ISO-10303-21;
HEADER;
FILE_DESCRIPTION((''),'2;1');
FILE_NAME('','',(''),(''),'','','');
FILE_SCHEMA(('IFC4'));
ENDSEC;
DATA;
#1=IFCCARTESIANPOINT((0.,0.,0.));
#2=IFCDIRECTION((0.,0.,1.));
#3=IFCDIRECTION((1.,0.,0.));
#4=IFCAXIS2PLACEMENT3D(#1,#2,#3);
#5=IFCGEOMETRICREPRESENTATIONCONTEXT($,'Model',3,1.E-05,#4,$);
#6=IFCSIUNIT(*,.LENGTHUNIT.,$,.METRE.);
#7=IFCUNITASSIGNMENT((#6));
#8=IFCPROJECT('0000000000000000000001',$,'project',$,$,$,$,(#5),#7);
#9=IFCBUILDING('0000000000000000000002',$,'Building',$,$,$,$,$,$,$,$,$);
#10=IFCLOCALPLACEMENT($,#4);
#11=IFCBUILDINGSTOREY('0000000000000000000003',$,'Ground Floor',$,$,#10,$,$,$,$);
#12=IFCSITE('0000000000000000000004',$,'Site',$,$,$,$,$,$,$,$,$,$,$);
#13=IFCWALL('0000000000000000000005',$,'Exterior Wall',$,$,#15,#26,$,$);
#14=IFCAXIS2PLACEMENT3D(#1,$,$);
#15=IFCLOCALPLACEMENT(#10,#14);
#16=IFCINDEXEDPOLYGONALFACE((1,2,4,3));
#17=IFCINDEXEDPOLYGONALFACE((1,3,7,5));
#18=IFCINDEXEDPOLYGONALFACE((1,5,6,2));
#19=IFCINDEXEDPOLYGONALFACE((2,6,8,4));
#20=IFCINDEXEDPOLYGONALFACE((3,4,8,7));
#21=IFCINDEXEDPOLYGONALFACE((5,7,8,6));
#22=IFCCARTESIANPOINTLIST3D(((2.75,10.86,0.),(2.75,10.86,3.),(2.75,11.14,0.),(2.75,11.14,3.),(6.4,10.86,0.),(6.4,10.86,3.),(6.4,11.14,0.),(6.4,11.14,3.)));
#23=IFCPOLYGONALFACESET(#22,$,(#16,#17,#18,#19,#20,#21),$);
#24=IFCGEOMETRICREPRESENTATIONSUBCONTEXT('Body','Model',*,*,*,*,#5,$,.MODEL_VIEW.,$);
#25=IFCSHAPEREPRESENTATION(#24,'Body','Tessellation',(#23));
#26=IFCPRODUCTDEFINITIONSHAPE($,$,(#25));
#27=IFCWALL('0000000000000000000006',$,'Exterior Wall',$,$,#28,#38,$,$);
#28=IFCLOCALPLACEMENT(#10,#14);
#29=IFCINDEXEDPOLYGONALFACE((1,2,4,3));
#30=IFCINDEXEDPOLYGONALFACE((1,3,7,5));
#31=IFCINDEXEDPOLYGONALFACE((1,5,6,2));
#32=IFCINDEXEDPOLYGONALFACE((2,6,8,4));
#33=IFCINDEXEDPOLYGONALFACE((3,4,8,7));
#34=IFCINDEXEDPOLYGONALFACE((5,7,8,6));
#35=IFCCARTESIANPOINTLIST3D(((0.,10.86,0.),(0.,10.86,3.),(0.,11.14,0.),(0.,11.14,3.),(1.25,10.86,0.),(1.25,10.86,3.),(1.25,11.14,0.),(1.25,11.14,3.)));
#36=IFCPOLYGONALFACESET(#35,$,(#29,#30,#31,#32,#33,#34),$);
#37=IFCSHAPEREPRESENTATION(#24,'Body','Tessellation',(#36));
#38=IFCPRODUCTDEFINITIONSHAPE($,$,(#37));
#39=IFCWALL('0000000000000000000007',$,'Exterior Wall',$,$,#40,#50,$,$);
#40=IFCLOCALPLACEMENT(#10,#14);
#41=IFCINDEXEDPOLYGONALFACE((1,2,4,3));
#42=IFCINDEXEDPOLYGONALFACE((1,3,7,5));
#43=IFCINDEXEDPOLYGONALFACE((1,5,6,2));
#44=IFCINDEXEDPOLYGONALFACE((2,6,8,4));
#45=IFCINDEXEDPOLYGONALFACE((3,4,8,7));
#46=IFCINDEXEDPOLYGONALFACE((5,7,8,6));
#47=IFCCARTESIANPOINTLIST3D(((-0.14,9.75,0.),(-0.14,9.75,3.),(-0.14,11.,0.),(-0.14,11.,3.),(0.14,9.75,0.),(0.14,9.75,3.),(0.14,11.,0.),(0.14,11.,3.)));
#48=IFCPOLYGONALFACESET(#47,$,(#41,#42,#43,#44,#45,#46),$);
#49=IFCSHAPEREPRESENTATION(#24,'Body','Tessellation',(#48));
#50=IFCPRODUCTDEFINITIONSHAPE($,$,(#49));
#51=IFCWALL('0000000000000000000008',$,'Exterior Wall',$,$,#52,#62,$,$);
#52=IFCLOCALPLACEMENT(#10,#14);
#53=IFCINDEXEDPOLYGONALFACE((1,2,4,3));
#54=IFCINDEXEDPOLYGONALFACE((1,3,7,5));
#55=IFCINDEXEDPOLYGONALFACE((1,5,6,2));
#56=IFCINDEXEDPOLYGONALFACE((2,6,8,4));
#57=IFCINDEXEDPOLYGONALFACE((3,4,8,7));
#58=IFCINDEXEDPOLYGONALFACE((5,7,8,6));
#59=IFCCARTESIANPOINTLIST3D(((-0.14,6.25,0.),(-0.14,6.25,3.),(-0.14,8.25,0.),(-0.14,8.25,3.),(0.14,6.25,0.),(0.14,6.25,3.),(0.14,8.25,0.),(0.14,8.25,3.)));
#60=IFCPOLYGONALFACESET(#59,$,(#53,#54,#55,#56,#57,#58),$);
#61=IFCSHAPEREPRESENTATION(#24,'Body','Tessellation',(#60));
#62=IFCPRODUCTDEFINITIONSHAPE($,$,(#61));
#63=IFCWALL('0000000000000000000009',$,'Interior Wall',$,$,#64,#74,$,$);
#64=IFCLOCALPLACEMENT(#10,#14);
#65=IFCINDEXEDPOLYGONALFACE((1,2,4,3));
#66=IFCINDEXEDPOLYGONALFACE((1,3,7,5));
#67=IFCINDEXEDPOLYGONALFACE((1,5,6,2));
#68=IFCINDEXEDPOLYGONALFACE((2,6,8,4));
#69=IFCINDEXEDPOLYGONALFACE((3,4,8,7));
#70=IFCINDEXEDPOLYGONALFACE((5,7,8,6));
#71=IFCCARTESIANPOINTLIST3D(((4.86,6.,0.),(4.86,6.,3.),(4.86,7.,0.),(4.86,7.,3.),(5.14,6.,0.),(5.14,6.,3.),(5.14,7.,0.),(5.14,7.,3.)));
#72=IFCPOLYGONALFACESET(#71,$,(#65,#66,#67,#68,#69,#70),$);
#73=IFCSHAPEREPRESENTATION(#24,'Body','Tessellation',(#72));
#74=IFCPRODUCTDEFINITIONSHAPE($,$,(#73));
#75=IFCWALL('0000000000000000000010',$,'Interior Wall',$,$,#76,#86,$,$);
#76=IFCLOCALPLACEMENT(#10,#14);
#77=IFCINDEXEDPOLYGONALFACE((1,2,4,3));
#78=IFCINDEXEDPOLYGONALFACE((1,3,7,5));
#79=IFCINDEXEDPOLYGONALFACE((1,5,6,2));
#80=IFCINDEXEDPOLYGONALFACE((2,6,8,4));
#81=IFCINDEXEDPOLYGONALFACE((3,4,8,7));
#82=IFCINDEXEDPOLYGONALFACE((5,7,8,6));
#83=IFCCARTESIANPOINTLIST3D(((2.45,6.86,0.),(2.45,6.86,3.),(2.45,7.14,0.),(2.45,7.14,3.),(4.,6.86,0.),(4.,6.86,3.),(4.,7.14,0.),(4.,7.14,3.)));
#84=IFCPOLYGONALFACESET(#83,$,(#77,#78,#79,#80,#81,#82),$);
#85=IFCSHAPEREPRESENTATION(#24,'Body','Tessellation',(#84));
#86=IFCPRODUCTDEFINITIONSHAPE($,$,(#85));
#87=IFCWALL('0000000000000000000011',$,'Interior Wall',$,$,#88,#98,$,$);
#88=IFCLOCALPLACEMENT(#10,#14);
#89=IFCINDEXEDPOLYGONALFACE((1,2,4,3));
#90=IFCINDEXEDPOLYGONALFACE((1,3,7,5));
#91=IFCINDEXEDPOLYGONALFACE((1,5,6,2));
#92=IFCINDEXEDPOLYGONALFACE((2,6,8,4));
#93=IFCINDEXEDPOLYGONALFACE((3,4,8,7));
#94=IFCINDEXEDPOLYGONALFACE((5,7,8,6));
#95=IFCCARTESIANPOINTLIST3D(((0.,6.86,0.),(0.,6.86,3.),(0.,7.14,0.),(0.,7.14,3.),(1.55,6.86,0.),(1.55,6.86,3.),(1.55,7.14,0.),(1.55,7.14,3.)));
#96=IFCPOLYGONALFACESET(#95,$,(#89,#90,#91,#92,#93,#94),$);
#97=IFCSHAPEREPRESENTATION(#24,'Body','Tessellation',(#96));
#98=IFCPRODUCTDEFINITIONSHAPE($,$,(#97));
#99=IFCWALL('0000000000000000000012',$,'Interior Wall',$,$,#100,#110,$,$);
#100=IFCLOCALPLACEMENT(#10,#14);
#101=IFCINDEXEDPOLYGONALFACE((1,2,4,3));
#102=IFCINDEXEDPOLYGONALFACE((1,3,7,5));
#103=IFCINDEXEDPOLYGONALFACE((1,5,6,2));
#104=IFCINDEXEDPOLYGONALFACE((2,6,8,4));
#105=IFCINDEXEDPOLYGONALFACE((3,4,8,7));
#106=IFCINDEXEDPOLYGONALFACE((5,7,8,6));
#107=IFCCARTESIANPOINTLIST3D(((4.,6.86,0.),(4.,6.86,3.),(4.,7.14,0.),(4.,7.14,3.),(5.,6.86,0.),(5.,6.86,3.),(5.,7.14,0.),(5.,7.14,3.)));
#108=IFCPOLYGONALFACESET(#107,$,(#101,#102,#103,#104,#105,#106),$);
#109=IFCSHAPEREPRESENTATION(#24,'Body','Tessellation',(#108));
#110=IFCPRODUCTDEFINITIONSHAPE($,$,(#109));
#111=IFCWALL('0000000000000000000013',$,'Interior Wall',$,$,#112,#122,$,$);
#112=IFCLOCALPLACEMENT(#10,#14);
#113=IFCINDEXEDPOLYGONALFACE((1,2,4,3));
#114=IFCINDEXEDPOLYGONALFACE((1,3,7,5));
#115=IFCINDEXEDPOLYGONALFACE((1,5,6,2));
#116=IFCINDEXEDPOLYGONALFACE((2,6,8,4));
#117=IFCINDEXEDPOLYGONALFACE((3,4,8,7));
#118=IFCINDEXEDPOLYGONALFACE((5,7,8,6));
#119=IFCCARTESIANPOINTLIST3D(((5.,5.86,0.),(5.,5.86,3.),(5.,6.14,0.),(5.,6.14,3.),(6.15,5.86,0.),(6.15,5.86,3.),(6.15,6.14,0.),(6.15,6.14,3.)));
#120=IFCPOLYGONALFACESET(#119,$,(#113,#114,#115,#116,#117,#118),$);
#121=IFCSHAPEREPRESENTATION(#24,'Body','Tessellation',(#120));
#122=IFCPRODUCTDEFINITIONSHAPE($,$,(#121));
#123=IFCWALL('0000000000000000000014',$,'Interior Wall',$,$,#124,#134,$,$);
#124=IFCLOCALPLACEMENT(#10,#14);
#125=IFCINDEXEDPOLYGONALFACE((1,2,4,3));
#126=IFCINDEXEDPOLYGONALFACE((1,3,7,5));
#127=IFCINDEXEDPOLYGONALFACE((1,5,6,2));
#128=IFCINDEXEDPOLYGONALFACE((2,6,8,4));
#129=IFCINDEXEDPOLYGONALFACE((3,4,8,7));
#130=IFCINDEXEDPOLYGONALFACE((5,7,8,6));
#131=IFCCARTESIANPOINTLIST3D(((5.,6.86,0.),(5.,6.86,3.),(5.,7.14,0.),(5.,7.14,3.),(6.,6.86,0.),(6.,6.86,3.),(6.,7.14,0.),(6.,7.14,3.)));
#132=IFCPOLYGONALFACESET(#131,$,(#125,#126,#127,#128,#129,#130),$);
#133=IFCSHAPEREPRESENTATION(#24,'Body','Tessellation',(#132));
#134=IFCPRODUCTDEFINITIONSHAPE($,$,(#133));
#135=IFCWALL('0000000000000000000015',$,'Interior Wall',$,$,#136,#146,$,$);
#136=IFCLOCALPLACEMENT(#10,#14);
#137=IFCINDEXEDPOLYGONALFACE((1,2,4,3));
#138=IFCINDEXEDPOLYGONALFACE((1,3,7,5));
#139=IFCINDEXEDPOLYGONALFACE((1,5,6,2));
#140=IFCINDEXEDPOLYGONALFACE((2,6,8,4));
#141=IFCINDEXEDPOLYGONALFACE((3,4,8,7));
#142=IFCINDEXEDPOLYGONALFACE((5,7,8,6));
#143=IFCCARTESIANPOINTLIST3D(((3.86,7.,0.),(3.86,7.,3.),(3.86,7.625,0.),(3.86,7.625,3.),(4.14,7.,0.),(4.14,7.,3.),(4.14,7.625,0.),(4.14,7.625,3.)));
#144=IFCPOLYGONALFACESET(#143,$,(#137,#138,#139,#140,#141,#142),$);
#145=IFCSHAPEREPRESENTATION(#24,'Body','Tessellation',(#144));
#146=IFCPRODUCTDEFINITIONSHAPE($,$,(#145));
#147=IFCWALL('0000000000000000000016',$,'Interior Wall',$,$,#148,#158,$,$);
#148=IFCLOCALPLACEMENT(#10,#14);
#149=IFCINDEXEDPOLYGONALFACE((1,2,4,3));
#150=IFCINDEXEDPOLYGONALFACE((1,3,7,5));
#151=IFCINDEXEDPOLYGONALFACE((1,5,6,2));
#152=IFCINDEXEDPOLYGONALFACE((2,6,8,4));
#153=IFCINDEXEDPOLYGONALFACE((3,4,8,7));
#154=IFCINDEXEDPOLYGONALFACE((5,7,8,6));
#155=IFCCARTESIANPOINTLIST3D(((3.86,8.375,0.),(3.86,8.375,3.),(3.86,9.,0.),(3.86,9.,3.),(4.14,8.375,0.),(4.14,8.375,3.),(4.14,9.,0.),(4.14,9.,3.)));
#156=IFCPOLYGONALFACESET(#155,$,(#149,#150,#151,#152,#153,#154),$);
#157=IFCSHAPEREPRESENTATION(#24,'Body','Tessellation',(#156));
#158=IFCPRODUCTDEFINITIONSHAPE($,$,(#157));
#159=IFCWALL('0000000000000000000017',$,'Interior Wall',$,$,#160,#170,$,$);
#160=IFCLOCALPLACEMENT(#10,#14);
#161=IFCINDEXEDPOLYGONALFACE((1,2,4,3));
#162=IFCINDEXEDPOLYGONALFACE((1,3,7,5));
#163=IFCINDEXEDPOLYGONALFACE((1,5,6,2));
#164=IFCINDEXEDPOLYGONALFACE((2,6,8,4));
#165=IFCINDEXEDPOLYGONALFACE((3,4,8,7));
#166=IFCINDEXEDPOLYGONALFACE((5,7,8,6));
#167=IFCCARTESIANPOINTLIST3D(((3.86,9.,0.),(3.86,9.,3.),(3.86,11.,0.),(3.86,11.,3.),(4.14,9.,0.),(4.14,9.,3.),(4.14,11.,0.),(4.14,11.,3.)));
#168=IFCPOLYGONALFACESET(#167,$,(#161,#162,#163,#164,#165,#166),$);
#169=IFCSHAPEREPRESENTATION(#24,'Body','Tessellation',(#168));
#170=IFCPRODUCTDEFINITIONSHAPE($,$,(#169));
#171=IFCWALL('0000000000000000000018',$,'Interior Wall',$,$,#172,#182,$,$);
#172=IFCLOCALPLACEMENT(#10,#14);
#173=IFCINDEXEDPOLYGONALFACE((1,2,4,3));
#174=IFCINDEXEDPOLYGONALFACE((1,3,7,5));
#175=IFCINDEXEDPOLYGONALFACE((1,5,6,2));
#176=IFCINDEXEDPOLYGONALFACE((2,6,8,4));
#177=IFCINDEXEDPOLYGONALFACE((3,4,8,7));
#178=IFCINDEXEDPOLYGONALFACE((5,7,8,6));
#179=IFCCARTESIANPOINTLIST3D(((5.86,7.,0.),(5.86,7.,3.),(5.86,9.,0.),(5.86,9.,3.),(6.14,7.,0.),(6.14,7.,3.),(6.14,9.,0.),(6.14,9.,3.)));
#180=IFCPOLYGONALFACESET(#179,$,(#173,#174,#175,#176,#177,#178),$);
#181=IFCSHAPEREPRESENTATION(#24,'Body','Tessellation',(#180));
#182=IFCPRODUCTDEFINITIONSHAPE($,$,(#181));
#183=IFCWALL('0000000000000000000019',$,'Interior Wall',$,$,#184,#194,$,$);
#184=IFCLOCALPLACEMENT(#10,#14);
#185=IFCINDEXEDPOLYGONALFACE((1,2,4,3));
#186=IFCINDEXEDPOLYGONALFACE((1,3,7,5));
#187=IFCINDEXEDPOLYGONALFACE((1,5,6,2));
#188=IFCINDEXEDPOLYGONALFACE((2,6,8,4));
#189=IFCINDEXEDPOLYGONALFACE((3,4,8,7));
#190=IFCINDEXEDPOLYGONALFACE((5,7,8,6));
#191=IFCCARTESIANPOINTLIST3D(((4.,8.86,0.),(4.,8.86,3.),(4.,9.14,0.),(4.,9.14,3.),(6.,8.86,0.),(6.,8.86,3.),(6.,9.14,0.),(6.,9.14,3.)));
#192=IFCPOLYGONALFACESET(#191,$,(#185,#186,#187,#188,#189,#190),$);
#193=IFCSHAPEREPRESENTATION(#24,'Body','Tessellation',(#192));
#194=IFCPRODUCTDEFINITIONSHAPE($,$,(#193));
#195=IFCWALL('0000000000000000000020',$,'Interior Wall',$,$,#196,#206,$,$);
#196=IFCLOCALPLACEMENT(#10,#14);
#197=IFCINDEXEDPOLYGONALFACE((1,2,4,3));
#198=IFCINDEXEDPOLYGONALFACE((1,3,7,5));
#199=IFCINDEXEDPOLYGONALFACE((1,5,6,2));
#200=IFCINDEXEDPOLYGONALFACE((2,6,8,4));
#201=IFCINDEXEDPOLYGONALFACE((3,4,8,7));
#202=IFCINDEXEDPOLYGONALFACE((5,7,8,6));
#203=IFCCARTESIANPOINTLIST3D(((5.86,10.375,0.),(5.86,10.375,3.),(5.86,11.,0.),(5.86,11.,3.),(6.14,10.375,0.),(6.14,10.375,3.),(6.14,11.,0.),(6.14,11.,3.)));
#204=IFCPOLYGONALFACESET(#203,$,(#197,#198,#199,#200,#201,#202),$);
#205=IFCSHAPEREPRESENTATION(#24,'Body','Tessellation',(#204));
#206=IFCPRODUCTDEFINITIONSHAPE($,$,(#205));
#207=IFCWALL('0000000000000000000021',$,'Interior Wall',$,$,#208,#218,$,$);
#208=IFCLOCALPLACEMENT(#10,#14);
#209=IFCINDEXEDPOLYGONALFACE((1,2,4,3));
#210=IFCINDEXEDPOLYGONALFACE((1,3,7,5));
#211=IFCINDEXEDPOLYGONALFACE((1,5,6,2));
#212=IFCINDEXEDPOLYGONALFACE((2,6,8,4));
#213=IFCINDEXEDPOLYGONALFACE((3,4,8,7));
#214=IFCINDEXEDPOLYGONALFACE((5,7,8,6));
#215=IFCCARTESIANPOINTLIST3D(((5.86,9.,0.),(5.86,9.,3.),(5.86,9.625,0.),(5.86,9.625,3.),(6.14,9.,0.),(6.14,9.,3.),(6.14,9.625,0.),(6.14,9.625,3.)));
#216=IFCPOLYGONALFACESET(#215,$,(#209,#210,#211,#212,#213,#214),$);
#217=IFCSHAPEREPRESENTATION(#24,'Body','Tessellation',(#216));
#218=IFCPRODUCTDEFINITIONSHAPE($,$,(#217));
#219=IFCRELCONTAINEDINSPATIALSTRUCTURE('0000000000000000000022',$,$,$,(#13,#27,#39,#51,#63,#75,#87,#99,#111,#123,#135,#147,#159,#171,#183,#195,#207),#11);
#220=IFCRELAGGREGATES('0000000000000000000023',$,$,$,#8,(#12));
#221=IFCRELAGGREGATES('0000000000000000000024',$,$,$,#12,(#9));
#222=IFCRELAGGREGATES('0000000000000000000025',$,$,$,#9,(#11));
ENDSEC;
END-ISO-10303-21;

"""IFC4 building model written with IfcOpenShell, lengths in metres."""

from ifc_helpers import new_model, si_unit, frame, origin_with_axes, place, context, subcontext, project, spatial, indexed_curve, outline, extrude, element, save


model = new_model("IFC4")

# Units and contexts
model_context = context("Model", 3, precision=1e-05, world=origin_with_axes())
body_context = subcontext(model_context, "Body", "Model", "MODEL_VIEW")
ifc_project = project(units=[si_unit("LENGTHUNIT", "METRE")], contexts=[model_context])

# Site, building, storey
site = spatial("IfcSite", under=ifc_project, Name="Site")
building = spatial("IfcBuilding", under=site, Name="Building")
storey_placement = place(None, origin_with_axes())
storey = spatial("IfcBuildingStorey", under=building, at=storey_placement, Name="Ground Floor")

# Walls
wall_1_placement = place(storey_placement, frame((6.4, 11.0, 0.0), z_axis=(0.0, 0.0, 1.0), x_axis=(-1.0, 0.0, 0.0)))
element("IfcWall", 1, at=wall_1_placement, inside=storey, Name="Exterior Wall", context=body_context, shape_type="SweptSolid", body=[
    extrude(outline(indexed_curve([(0.0, 0.0), (0.0, 0.28), (3.65, 0.28), (3.65, 0.0), (0.0, 0.0)], self_intersect=False)), frame((0.0, -0.14, 0.0), z_axis=(0.0, 0.0, 1.0), x_axis=(1.0, 0.0, 0.0)), (0.0, 0.0, 1.0), 3.0),
])
for number, where, z_axis, x_axis, name in (
    (2, (1.25, 11.0, 0.0), (0.0, 0.0, 1.0), (-1.0, 0.0, 0.0), "Exterior Wall"),
    (3, (0.0, 11.0, 0.0), (0.0, 0.0, 1.0), (0.0, -1.0, 0.0), "Exterior Wall"),
):
    element("IfcWall", number, at=place(storey_placement, frame(where, z_axis=z_axis, x_axis=x_axis)), inside=storey, Name=name, context=body_context, shape_type="SweptSolid", body=[
        extrude(outline(indexed_curve([(0.0, 0.0), (0.0, 0.28), (1.25, 0.28), (1.25, 0.0), (0.0, 0.0)], self_intersect=False)), frame((0.0, -0.14, 0.0), z_axis=(0.0, 0.0, 1.0), x_axis=(1.0, 0.0, 0.0)), (0.0, 0.0, 1.0), 3.0),
    ])
wall_2_placement = place(storey_placement, frame((0.0, 8.25, 0.0), z_axis=(0.0, 0.0, 1.0), x_axis=(0.0, -1.0, 0.0)))
element("IfcWall", 4, at=wall_2_placement, inside=storey, Name="Exterior Wall", context=body_context, shape_type="SweptSolid", body=[
    extrude(outline(indexed_curve([(0.0, 0.0), (0.0, 0.28), (2.0, 0.28), (2.0, 0.0), (0.0, 0.0)], self_intersect=False)), frame((0.0, -0.14, 0.0), z_axis=(0.0, 0.0, 1.0), x_axis=(1.0, 0.0, 0.0)), (0.0, 0.0, 1.0), 3.0),
])
wall_3_placement = place(storey_placement, frame((5.0, 6.0, 0.0), z_axis=(0.0, 0.0, 1.0), x_axis=(0.0, 1.0, 0.0)))
element("IfcWall", 5, at=wall_3_placement, inside=storey, Name="Interior Wall", context=body_context, shape_type="SweptSolid", body=[
    extrude(outline(indexed_curve([(0.0, 0.0), (0.0, 0.28), (1.0, 0.28), (1.0, 0.0), (0.0, 0.0)], self_intersect=False)), frame((0.0, -0.14, 0.0), z_axis=(0.0, 0.0, 1.0), x_axis=(1.0, 0.0, 0.0)), (0.0, 0.0, 1.0), 3.0),
])
for number, where, z_axis, x_axis, name in (
    (6, (4.0, 7.0, 0.0), (0.0, 0.0, 1.0), (-1.0, 0.0, 0.0), "Interior Wall"),
    (7, (1.55, 7.0, 0.0), (0.0, 0.0, 1.0), (-1.0, 0.0, 0.0), "Interior Wall"),
):
    element("IfcWall", number, at=place(storey_placement, frame(where, z_axis=z_axis, x_axis=x_axis)), inside=storey, Name=name, context=body_context, shape_type="SweptSolid", body=[
        extrude(outline(indexed_curve([(0.0, 0.0), (0.0, 0.28), (1.55, 0.28), (1.55, 0.0), (0.0, 0.0)], self_intersect=False)), frame((0.0, -0.14, 0.0), z_axis=(0.0, 0.0, 1.0), x_axis=(1.0, 0.0, 0.0)), (0.0, 0.0, 1.0), 3.0),
    ])
wall_4_placement = place(storey_placement, frame((5.0, 7.0, 0.0), z_axis=(0.0, 0.0, 1.0), x_axis=(-1.0, 0.0, 0.0)))
element("IfcWall", 8, at=wall_4_placement, inside=storey, Name="Interior Wall", context=body_context, shape_type="SweptSolid", body=[
    extrude(outline(indexed_curve([(0.0, 0.0), (0.0, 0.28), (1.0, 0.28), (1.0, 0.0), (0.0, 0.0)], self_intersect=False)), frame((0.0, -0.14, 0.0), z_axis=(0.0, 0.0, 1.0), x_axis=(1.0, 0.0, 0.0)), (0.0, 0.0, 1.0), 3.0),
])
wall_5_placement = place(storey_placement, frame((6.15, 6.0, 0.0), z_axis=(0.0, 0.0, 1.0), x_axis=(-1.0, 0.0, 0.0)))
element("IfcWall", 9, at=wall_5_placement, inside=storey, Name="Interior Wall", context=body_context, shape_type="SweptSolid", body=[
    extrude(outline(indexed_curve([(0.0, 0.0), (0.0, 0.28), (1.15, 0.28), (1.15, 0.0), (0.0, 0.0)], self_intersect=False)), frame((0.0, -0.14, 0.0), z_axis=(0.0, 0.0, 1.0), x_axis=(1.0, 0.0, 0.0)), (0.0, 0.0, 1.0), 3.0),
])
wall_6_placement = place(storey_placement, frame((6.0, 7.0, 0.0), z_axis=(0.0, 0.0, 1.0), x_axis=(-1.0, 0.0, 0.0)))
element("IfcWall", 10, at=wall_6_placement, inside=storey, Name="Interior Wall", context=body_context, shape_type="SweptSolid", body=[
    extrude(outline(indexed_curve([(0.0, 0.0), (0.0, 0.28), (1.0, 0.28), (1.0, 0.0), (0.0, 0.0)], self_intersect=False)), frame((0.0, -0.14, 0.0), z_axis=(0.0, 0.0, 1.0), x_axis=(1.0, 0.0, 0.0)), (0.0, 0.0, 1.0), 3.0),
])
for number, where, z_axis, x_axis, name in (
    (11, (4.0, 7.0, 0.0), (0.0, 0.0, 1.0), (0.0, 1.0, 0.0), "Interior Wall"),
    (12, (4.0, 8.375, 0.0), (0.0, 0.0, 1.0), (0.0, 1.0, 0.0), "Interior Wall"),
):
    element("IfcWall", number, at=place(storey_placement, frame(where, z_axis=z_axis, x_axis=x_axis)), inside=storey, Name=name, context=body_context, shape_type="SweptSolid", body=[
        extrude(outline(indexed_curve([(0.0, 0.0), (0.0, 0.28), (0.625, 0.28), (0.625, 0.0), (0.0, 0.0)], self_intersect=False)), frame((0.0, -0.14, 0.0), z_axis=(0.0, 0.0, 1.0), x_axis=(1.0, 0.0, 0.0)), (0.0, 0.0, 1.0), 3.0),
    ])
for number, where, z_axis, x_axis, name in (
    (13, (4.0, 9.0, 0.0), (0.0, 0.0, 1.0), (0.0, 1.0, 0.0), "Interior Wall"),
    (14, (6.0, 7.0, 0.0), (0.0, 0.0, 1.0), (0.0, 1.0, 0.0), "Interior Wall"),
    (15, (6.0, 9.0, 0.0), (0.0, 0.0, 1.0), (-1.0, 0.0, 0.0), "Interior Wall"),
):
    element("IfcWall", number, at=place(storey_placement, frame(where, z_axis=z_axis, x_axis=x_axis)), inside=storey, Name=name, context=body_context, shape_type="SweptSolid", body=[
        extrude(outline(indexed_curve([(0.0, 0.0), (0.0, 0.28), (2.0, 0.28), (2.0, 0.0), (0.0, 0.0)], self_intersect=False)), frame((0.0, -0.14, 0.0), z_axis=(0.0, 0.0, 1.0), x_axis=(1.0, 0.0, 0.0)), (0.0, 0.0, 1.0), 3.0),
    ])
for number, where, z_axis, x_axis, name in (
    (16, (6.0, 11.0, 0.0), (0.0, 0.0, 1.0), (0.0, -1.0, 0.0), "Interior Wall"),
    (17, (6.0, 9.625, 0.0), (0.0, 0.0, 1.0), (0.0, -1.0, 0.0), "Interior Wall"),
):
    element("IfcWall", number, at=place(storey_placement, frame(where, z_axis=z_axis, x_axis=x_axis)), inside=storey, Name=name, context=body_context, shape_type="SweptSolid", body=[
        extrude(outline(indexed_curve([(0.0, 0.0), (0.0, 0.28), (0.625, 0.28), (0.625, 0.0), (0.0, 0.0)], self_intersect=False)), frame((0.0, -0.14, 0.0), z_axis=(0.0, 0.0, 1.0), x_axis=(1.0, 0.0, 0.0)), (0.0, 0.0, 1.0), 3.0),
    ])

save(model, "model.ifc")
